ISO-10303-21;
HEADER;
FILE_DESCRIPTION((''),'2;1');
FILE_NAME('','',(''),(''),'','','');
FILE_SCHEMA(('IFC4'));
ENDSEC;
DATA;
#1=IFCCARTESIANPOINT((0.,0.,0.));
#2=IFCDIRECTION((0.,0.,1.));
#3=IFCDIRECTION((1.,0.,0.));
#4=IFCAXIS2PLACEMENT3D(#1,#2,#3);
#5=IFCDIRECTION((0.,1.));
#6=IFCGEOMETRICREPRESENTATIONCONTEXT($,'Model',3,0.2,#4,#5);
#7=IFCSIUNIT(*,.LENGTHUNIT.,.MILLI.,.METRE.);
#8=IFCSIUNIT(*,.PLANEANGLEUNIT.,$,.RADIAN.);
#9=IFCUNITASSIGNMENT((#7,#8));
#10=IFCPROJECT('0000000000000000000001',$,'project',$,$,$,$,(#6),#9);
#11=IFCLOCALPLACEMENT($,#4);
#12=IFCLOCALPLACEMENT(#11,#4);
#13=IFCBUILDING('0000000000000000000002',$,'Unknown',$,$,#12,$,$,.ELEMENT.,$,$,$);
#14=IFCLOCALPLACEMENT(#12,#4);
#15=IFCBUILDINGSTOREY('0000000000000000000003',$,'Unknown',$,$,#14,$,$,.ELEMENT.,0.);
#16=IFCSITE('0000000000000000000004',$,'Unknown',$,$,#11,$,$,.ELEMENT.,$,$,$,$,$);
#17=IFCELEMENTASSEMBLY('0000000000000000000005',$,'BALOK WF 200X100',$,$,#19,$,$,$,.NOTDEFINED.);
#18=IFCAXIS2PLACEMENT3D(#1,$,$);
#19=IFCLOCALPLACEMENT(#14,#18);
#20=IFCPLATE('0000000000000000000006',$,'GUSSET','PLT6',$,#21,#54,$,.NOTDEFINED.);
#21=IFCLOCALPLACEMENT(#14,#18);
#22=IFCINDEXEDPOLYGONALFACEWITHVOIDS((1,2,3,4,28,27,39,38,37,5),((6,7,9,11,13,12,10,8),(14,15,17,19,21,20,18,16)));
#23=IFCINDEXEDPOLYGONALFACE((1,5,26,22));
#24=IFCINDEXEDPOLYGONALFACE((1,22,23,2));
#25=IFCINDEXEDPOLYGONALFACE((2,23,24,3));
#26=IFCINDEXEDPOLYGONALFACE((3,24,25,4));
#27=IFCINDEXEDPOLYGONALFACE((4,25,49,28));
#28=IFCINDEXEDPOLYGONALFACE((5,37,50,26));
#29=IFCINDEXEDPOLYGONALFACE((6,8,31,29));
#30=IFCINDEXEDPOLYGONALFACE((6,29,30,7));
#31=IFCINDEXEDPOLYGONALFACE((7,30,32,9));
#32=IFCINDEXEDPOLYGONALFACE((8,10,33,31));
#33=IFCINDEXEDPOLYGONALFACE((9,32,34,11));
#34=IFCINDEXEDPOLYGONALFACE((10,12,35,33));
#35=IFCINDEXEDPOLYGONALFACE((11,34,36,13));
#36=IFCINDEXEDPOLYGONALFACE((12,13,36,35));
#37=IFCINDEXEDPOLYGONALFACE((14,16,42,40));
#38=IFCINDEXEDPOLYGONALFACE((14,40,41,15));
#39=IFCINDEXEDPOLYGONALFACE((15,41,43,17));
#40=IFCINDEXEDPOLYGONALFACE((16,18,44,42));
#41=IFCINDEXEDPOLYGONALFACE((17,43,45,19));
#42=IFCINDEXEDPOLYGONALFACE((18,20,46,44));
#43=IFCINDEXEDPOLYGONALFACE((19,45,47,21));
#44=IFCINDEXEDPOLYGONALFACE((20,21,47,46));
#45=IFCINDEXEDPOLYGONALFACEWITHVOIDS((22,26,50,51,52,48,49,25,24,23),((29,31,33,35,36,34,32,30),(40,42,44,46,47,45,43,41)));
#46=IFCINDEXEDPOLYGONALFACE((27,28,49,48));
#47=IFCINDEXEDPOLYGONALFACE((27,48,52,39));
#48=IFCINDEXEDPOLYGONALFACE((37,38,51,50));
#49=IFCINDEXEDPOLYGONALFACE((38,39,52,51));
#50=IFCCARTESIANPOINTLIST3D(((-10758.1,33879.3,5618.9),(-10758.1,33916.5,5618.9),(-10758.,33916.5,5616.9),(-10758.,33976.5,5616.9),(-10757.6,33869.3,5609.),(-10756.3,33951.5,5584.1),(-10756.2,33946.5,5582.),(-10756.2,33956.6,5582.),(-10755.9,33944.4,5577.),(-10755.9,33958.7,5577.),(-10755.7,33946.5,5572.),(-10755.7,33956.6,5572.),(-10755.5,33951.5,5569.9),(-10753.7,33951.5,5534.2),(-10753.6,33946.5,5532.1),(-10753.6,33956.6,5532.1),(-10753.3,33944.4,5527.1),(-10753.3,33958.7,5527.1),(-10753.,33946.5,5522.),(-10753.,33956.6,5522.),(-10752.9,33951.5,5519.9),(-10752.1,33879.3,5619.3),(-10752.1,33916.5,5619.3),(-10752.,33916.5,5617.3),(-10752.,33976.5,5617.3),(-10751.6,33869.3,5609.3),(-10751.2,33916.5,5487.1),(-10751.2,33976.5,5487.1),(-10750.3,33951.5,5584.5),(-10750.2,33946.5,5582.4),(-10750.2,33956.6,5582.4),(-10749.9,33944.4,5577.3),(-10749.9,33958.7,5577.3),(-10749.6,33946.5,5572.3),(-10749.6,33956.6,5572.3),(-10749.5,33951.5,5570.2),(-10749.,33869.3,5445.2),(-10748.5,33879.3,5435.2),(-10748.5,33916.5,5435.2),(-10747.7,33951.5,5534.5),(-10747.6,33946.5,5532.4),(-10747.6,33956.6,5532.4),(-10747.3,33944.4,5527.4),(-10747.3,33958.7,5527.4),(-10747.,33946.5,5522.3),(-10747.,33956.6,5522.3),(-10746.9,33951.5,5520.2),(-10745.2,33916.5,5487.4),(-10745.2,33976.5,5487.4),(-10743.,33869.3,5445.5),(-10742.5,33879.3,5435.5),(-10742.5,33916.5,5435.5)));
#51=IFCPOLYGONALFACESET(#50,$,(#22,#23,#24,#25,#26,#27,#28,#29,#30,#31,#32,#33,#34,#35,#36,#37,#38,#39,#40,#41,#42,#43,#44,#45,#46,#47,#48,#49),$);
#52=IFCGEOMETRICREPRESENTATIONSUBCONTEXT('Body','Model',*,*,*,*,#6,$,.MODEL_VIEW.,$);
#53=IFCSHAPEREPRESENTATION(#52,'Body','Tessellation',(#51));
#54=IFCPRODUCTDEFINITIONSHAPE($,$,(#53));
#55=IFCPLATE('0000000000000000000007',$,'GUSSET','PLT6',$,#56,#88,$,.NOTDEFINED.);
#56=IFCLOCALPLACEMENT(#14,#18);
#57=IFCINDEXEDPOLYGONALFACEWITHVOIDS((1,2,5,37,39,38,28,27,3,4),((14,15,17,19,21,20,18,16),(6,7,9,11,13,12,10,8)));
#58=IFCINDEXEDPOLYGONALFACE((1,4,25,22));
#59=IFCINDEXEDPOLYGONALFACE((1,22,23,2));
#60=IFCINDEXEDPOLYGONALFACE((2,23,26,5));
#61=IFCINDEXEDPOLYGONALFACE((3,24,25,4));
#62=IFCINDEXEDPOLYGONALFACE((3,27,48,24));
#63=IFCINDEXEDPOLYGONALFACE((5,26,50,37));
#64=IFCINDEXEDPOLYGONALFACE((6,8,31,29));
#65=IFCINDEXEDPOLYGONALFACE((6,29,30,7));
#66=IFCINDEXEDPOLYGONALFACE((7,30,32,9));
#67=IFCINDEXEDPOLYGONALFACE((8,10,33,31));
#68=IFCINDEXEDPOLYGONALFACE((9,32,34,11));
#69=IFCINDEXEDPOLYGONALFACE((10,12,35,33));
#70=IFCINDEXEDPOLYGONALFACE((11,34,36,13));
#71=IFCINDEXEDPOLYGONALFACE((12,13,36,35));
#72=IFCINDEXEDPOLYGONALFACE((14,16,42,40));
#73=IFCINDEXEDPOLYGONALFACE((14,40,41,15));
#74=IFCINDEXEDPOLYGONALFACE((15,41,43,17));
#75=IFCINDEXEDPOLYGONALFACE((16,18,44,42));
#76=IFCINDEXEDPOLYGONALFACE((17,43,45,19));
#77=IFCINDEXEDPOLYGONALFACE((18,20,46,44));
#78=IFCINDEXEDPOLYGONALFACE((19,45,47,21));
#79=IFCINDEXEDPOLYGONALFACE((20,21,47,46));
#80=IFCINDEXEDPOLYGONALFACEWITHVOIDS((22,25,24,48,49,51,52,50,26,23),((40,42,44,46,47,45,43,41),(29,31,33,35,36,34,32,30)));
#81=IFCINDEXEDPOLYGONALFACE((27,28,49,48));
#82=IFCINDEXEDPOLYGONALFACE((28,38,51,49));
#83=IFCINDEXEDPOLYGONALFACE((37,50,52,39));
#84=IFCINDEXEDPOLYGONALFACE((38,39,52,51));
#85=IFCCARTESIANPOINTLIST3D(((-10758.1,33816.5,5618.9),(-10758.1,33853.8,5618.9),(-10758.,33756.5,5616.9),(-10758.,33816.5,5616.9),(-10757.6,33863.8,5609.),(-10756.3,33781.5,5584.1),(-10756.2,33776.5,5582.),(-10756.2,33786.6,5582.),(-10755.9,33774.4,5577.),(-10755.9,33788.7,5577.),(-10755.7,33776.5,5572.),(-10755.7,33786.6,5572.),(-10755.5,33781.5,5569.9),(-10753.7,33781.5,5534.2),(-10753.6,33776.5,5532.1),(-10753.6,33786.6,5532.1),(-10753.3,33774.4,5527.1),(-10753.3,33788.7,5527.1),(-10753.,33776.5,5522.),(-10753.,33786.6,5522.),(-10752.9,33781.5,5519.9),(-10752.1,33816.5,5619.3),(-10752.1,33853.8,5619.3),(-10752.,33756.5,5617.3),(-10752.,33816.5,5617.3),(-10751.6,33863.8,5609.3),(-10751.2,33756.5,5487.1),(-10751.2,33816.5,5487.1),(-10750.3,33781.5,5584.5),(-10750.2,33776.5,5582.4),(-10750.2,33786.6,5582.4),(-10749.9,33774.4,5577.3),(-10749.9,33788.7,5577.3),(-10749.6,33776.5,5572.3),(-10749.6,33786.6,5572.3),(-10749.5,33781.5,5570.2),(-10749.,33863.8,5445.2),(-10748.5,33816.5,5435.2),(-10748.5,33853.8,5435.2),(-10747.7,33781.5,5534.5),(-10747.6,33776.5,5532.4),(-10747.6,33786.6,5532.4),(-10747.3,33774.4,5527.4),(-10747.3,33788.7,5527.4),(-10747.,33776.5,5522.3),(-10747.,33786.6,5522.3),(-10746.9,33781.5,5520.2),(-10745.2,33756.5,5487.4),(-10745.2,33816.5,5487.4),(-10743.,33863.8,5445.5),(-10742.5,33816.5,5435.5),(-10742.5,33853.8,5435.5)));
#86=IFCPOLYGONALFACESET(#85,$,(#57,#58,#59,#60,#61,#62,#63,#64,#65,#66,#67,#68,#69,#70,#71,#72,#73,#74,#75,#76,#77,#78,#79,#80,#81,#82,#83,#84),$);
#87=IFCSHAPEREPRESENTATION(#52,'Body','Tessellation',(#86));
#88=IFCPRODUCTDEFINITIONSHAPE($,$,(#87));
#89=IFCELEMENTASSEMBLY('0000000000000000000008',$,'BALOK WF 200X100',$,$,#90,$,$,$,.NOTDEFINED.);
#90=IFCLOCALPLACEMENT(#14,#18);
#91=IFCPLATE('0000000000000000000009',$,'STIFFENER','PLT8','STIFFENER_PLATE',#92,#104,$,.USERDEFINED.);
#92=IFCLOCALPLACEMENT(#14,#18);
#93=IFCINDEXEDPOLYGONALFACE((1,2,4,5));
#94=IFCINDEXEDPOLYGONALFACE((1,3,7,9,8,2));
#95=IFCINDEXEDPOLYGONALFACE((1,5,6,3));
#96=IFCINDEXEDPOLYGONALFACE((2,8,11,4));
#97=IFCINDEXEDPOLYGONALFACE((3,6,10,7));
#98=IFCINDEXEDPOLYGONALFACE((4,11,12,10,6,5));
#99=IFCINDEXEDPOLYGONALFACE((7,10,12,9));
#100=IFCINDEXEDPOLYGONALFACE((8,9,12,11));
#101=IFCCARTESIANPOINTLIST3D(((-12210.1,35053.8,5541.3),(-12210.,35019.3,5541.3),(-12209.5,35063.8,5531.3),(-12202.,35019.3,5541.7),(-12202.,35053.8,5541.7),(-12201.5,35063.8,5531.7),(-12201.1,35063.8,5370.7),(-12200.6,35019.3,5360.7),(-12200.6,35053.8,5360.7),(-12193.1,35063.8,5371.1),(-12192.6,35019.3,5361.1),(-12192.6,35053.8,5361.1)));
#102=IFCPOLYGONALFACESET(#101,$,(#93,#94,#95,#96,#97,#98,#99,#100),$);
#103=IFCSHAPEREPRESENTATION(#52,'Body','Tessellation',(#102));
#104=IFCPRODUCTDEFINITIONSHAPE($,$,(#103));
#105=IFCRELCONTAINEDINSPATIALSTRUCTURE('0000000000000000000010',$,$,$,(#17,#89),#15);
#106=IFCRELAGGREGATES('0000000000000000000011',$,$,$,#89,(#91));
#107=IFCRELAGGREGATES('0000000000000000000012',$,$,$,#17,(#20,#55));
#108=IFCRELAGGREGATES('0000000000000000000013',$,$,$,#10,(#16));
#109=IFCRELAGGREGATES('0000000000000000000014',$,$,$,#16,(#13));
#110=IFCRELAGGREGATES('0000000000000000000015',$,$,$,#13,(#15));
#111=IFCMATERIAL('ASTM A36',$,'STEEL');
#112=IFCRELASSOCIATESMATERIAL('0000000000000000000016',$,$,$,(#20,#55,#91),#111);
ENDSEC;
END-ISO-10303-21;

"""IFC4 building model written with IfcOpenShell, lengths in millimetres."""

from ifc_helpers import new_model, si_unit, direction, frame, origin_with_axes, place, context, subcontext, project, spatial, line, indexed_curve, outline, extrude, material, element, aggregate, save


model = new_model("IFC4")

# Units and contexts
model_context = context("Model", 3, precision=0.2, world=origin_with_axes(), true_north=direction((0.0, 1.0)))
body_context = subcontext(model_context, "Body", "Model", "MODEL_VIEW")
ifc_project = project(units=[si_unit("LENGTHUNIT", "METRE", prefix="MILLI"), si_unit("PLANEANGLEUNIT", "RADIAN")], contexts=[model_context])

# Site, building, storey
site_placement = place(None, origin_with_axes())
site = spatial("IfcSite", under=ifc_project, at=site_placement, Name="Unknown", CompositionType="ELEMENT")
building_placement = place(site_placement, origin_with_axes())
building = spatial("IfcBuilding", under=site, at=building_placement, Name="Unknown", CompositionType="ELEMENT")
storey_placement = place(building_placement, origin_with_axes())
storey = spatial("IfcBuildingStorey", under=building, at=storey_placement, Name="Unknown", CompositionType="ELEMENT", Elevation=0.0)

# Element assemblies, plates, voiding features
assembly_1_placement = place(storey_placement, frame((-7044.1, 33866.5, 5721.5), z_axis=(0.0, 1.0, 0.0), x_axis=(-0.99863, 0.0, -0.052336)))
assembly_1 = element("IfcElementAssembly", 1, at=assembly_1_placement, inside=storey, Name="BALOK WF 200X100", PredefinedType="NOTDEFINED")
ifc_material_1 = material(Name="ASTM A36", Category="STEEL")
plate_1_placement = place(assembly_1_placement, frame((3711.2, 92.0, 2.8), z_axis=(1.0, 0.0, 0.0), x_axis=(0.0, 0.0, 1.0)))
plate_1 = element("IfcPlate", 2, at=plate_1_placement, material=ifc_material_1, Name="GUSSET", Description="PLT6", PredefinedType="NOTDEFINED", context=body_context, shape_type="SolidModel", body=[
    extrude(outline(indexed_curve([(0.0, 0.0), (47.2, 0.0), (47.2, 2.0), (107.3, 2.0), (107.3, 132.0), (47.2, 132.0), (47.2, 184.0), (0.0, 184.0)], segments=[line(1, 2, 3, 4, 5, 6, 7, 8, 1)])), frame((0.0, 0.0, 3.0), z_axis=(0.0, 0.0, 1.0), x_axis=(1.0, 0.0, 0.0)), (0.0, 0.0, -1.0), 6.0),
])
voiding_feature_1_placement = place(plate_1_placement, frame((10.0, 0.0, 0.0), z_axis=(0.0, 0.0, 1.0), x_axis=(-0.707107, 0.707107, 0.0)))
element("IfcVoidingFeature", 3, at=voiding_feature_1_placement, cuts=plate_1, Name="SLAB", PredefinedType="HOLE", context=body_context, shape_type="SolidModel", body=[
    extrude(outline(indexed_curve([(0.0, 0.0), (14.1, 0.0), (7.1, 7.1)], segments=[line(1, 2, 3, 1)])), frame((0.0, 0.0, 3.0), z_axis=(0.0, 0.0, 1.0), x_axis=(1.0, 0.0, 0.0)), (0.0, 0.0, -1.0), 6.0),
])
voiding_feature_2_placement = place(plate_1_placement, frame((0.0, 174.0, 0.0), z_axis=(0.0, 0.0, 1.0), x_axis=(0.707107, 0.707107, 0.0)))
element("IfcVoidingFeature", 4, at=voiding_feature_2_placement, cuts=plate_1, Name="SLAB", PredefinedType="HOLE", context=body_context, shape_type="SolidModel", body=[
    extrude(outline(indexed_curve([(0.0, 0.0), (14.1, 0.0), (7.1, 7.1)], segments=[line(1, 2, 3, 1)])), frame((0.0, 0.0, 3.0), z_axis=(0.0, 0.0, 1.0), x_axis=(1.0, 0.0, 0.0)), (0.0, 0.0, -1.0), 6.0),
])
voiding_feature_3_placement = place(plate_1_placement, frame((82.3, 92.0, -3.5), z_axis=(-1.0, 0.0, 0.0), x_axis=(0.0, 0.0, 1.0)))
element("IfcVoidingFeature", 5, at=voiding_feature_3_placement, cuts=plate_1, Name="BEAM", PredefinedType="HOLE", context=body_context, shape_type="SolidModel", body=[
    extrude(outline(indexed_curve([(7.1, 0.0), (5.1, 5.1), (0.0, 7.1), (-5.1, 5.1), (-7.1, 0.0), (-5.1, -5.1), (0.0, -7.1), (5.1, -5.1)], segments=[line(1, 2, 3, 4, 5, 6, 7, 8, 1)])), frame((0.0, 0.0, 0.0), z_axis=(-1.0, 0.0, 0.0), x_axis=(0.0, 0.0, 1.0)), (0.0, 0.0, -1.0), 7.0),
])
voiding_feature_4_placement = place(plate_1_placement, frame((82.3, 42.0, -3.5), z_axis=(-1.0, 0.0, 0.0), x_axis=(0.0, 0.0, 1.0)))
element("IfcVoidingFeature", 6, at=voiding_feature_4_placement, cuts=plate_1, Name="BEAM", PredefinedType="HOLE", context=body_context, shape_type="SolidModel", body=[
    extrude(outline(indexed_curve([(7.1, 0.0), (5.1, 5.1), (0.0, 7.1), (-5.1, 5.1), (-7.1, 0.0), (-5.1, -5.1), (0.0, -7.1), (5.1, -5.1)], segments=[line(1, 2, 3, 4, 5, 6, 7, 8, 1)])), frame((0.0, 0.0, 0.0), z_axis=(-1.0, 0.0, 0.0), x_axis=(0.0, 0.0, 1.0)), (0.0, 0.0, -1.0), 7.0),
])
plate_2_placement = place(assembly_1_placement, frame((3711.2, -92.0, -2.8), z_axis=(1.0, 0.0, 0.0), x_axis=(0.0, 0.0, -1.0)))
plate_2 = element("IfcPlate", 7, at=plate_2_placement, material=ifc_material_1, Name="GUSSET", Description="PLT6", PredefinedType="NOTDEFINED", context=body_context, shape_type="SolidModel", body=[
    extrude(outline(indexed_curve([(0.0, 0.0), (47.2, 0.0), (47.2, 52.0), (107.3, 52.0), (107.3, 182.0), (47.2, 182.0), (47.2, 184.0), (0.0, 184.0)], segments=[line(1, 2, 3, 4, 5, 6, 7, 8, 1)])), frame((0.0, 0.0, 3.0), z_axis=(0.0, 0.0, 1.0), x_axis=(1.0, 0.0, 0.0)), (0.0, 0.0, -1.0), 6.0),
])
voiding_feature_5_placement = place(plate_2_placement, frame((0.0, 174.0, 0.0), z_axis=(0.0, 0.0, 1.0), x_axis=(0.707107, 0.707107, 0.0)))
element("IfcVoidingFeature", 8, at=voiding_feature_5_placement, cuts=plate_2, Name="SLAB", PredefinedType="HOLE", context=body_context, shape_type="SolidModel", body=[
    extrude(outline(indexed_curve([(0.0, 0.0), (14.1, 0.0), (7.1, 7.1)], segments=[line(1, 2, 3, 1)])), frame((0.0, 0.0, 3.0), z_axis=(0.0, 0.0, 1.0), x_axis=(1.0, 0.0, 0.0)), (0.0, 0.0, -1.0), 6.0),
])
voiding_feature_6_placement = place(plate_2_placement, origin_with_axes())
element("IfcVoidingFeature", 9, at=voiding_feature_6_placement, cuts=plate_2, Name="SLAB", PredefinedType="HOLE", context=body_context, shape_type="SolidModel", body=[
    extrude(outline(indexed_curve([(0.0, 0.0), (10.0, 0.0), (0.0, 10.0)], segments=[line(1, 2, 3, 1)])), frame((0.0, 0.0, 3.0), z_axis=(0.0, 0.0, 1.0), x_axis=(1.0, 0.0, 0.0)), (0.0, 0.0, -1.0), 6.0),
])
voiding_feature_7_placement = place(plate_2_placement, frame((82.3, 92.0, 3.5), z_axis=(1.0, 0.0, 0.0), x_axis=(0.0, 0.0, -1.0)))
element("IfcVoidingFeature", 10, at=voiding_feature_7_placement, cuts=plate_2, Name="BEAM", PredefinedType="HOLE", context=body_context, shape_type="SolidModel", body=[
    extrude(outline(indexed_curve([(7.1, 0.0), (5.1, 5.1), (0.0, 7.1), (-5.1, 5.1), (-7.1, 0.0), (-5.1, -5.1), (0.0, -7.1), (5.1, -5.1)], segments=[line(1, 2, 3, 4, 5, 6, 7, 8, 1)])), frame((0.0, 0.0, 0.0), z_axis=(-1.0, 0.0, 0.0), x_axis=(0.0, 0.0, 1.0)), (0.0, 0.0, -1.0), 7.0),
])
voiding_feature_8_placement = place(plate_2_placement, frame((82.3, 142.0, 3.5), z_axis=(1.0, 0.0, 0.0), x_axis=(0.0, 0.0, -1.0)))
element("IfcVoidingFeature", 11, at=voiding_feature_8_placement, cuts=plate_2, Name="BEAM", PredefinedType="HOLE", context=body_context, shape_type="SolidModel", body=[
    extrude(outline(indexed_curve([(7.1, 0.0), (5.1, 5.1), (0.0, 7.1), (-5.1, 5.1), (-7.1, 0.0), (-5.1, -5.1), (0.0, -7.1), (5.1, -5.1)], segments=[line(1, 2, 3, 4, 5, 6, 7, 8, 1)])), frame((0.0, 0.0, 0.0), z_axis=(-1.0, 0.0, 0.0), x_axis=(0.0, 0.0, 1.0)), (0.0, 0.0, -1.0), 7.0),
])
assembly_2_placement = place(storey_placement, frame((-12592.0, 35066.5, 5430.7), z_axis=(0.0, -1.0, 0.0), x_axis=(0.99863, 0.0, 0.052336)))
assembly_2 = element("IfcElementAssembly", 12, at=assembly_2_placement, inside=storey, Name="BALOK WF 200X100", PredefinedType="NOTDEFINED")
plate_3_placement = place(assembly_2_placement, frame((391.2, -90.4, 47.2), z_axis=(1.0, 0.0, 0.0), x_axis=(0.0, 0.0, -1.0)))
plate_3 = element("IfcPlate", 13, at=plate_3_placement, material=ifc_material_1, Name="STIFFENER", Description="PLT8", ObjectType="STIFFENER_PLATE", PredefinedType="USERDEFINED", context=body_context, shape_type="SolidModel", body=[
    extrude(outline(indexed_curve([(0.0, 0.0), (44.5, 0.0), (44.5, 180.8), (0.0, 180.8)], segments=[line(1, 2, 3, 4, 1)])), frame((0.0, 0.0, 4.0), z_axis=(0.0, 0.0, 1.0), x_axis=(1.0, 0.0, 0.0)), (0.0, 0.0, -1.0), 8.0),
])
voiding_feature_9_placement = place(plate_3_placement, frame((34.5, 180.8, 0.0), z_axis=(0.0, 0.0, 1.0), x_axis=(0.707107, -0.707107, 0.0)))
element("IfcVoidingFeature", 14, at=voiding_feature_9_placement, cuts=plate_3, Name="SLAB", PredefinedType="HOLE", context=body_context, shape_type="SolidModel", body=[
    extrude(outline(indexed_curve([(0.0, 0.0), (14.1, 0.0), (7.1, 7.1)], segments=[line(1, 2, 3, 1)])), frame((0.0, 0.0, 4.0), z_axis=(0.0, 0.0, 1.0), x_axis=(1.0, 0.0, 0.0)), (0.0, 0.0, -1.0), 8.0),
])
voiding_feature_10_placement = place(plate_3_placement, frame((34.5, 0.0, 0.0), z_axis=(0.0, 0.0, 1.0), x_axis=(1.0, 0.0, 0.0)))
element("IfcVoidingFeature", 15, at=voiding_feature_10_placement, cuts=plate_3, Name="SLAB", PredefinedType="HOLE", context=body_context, shape_type="SolidModel", body=[
    extrude(outline(indexed_curve([(0.0, 0.0), (10.0, 0.0), (10.0, 10.0)], segments=[line(1, 2, 3, 1)])), frame((0.0, 0.0, 4.0), z_axis=(0.0, 0.0, 1.0), x_axis=(1.0, 0.0, 0.0)), (0.0, 0.0, -1.0), 8.0),
])
aggregate(assembly_2, [plate_3])

aggregate(assembly_1, [plate_1, plate_2])

save(model, "model.ifc")
